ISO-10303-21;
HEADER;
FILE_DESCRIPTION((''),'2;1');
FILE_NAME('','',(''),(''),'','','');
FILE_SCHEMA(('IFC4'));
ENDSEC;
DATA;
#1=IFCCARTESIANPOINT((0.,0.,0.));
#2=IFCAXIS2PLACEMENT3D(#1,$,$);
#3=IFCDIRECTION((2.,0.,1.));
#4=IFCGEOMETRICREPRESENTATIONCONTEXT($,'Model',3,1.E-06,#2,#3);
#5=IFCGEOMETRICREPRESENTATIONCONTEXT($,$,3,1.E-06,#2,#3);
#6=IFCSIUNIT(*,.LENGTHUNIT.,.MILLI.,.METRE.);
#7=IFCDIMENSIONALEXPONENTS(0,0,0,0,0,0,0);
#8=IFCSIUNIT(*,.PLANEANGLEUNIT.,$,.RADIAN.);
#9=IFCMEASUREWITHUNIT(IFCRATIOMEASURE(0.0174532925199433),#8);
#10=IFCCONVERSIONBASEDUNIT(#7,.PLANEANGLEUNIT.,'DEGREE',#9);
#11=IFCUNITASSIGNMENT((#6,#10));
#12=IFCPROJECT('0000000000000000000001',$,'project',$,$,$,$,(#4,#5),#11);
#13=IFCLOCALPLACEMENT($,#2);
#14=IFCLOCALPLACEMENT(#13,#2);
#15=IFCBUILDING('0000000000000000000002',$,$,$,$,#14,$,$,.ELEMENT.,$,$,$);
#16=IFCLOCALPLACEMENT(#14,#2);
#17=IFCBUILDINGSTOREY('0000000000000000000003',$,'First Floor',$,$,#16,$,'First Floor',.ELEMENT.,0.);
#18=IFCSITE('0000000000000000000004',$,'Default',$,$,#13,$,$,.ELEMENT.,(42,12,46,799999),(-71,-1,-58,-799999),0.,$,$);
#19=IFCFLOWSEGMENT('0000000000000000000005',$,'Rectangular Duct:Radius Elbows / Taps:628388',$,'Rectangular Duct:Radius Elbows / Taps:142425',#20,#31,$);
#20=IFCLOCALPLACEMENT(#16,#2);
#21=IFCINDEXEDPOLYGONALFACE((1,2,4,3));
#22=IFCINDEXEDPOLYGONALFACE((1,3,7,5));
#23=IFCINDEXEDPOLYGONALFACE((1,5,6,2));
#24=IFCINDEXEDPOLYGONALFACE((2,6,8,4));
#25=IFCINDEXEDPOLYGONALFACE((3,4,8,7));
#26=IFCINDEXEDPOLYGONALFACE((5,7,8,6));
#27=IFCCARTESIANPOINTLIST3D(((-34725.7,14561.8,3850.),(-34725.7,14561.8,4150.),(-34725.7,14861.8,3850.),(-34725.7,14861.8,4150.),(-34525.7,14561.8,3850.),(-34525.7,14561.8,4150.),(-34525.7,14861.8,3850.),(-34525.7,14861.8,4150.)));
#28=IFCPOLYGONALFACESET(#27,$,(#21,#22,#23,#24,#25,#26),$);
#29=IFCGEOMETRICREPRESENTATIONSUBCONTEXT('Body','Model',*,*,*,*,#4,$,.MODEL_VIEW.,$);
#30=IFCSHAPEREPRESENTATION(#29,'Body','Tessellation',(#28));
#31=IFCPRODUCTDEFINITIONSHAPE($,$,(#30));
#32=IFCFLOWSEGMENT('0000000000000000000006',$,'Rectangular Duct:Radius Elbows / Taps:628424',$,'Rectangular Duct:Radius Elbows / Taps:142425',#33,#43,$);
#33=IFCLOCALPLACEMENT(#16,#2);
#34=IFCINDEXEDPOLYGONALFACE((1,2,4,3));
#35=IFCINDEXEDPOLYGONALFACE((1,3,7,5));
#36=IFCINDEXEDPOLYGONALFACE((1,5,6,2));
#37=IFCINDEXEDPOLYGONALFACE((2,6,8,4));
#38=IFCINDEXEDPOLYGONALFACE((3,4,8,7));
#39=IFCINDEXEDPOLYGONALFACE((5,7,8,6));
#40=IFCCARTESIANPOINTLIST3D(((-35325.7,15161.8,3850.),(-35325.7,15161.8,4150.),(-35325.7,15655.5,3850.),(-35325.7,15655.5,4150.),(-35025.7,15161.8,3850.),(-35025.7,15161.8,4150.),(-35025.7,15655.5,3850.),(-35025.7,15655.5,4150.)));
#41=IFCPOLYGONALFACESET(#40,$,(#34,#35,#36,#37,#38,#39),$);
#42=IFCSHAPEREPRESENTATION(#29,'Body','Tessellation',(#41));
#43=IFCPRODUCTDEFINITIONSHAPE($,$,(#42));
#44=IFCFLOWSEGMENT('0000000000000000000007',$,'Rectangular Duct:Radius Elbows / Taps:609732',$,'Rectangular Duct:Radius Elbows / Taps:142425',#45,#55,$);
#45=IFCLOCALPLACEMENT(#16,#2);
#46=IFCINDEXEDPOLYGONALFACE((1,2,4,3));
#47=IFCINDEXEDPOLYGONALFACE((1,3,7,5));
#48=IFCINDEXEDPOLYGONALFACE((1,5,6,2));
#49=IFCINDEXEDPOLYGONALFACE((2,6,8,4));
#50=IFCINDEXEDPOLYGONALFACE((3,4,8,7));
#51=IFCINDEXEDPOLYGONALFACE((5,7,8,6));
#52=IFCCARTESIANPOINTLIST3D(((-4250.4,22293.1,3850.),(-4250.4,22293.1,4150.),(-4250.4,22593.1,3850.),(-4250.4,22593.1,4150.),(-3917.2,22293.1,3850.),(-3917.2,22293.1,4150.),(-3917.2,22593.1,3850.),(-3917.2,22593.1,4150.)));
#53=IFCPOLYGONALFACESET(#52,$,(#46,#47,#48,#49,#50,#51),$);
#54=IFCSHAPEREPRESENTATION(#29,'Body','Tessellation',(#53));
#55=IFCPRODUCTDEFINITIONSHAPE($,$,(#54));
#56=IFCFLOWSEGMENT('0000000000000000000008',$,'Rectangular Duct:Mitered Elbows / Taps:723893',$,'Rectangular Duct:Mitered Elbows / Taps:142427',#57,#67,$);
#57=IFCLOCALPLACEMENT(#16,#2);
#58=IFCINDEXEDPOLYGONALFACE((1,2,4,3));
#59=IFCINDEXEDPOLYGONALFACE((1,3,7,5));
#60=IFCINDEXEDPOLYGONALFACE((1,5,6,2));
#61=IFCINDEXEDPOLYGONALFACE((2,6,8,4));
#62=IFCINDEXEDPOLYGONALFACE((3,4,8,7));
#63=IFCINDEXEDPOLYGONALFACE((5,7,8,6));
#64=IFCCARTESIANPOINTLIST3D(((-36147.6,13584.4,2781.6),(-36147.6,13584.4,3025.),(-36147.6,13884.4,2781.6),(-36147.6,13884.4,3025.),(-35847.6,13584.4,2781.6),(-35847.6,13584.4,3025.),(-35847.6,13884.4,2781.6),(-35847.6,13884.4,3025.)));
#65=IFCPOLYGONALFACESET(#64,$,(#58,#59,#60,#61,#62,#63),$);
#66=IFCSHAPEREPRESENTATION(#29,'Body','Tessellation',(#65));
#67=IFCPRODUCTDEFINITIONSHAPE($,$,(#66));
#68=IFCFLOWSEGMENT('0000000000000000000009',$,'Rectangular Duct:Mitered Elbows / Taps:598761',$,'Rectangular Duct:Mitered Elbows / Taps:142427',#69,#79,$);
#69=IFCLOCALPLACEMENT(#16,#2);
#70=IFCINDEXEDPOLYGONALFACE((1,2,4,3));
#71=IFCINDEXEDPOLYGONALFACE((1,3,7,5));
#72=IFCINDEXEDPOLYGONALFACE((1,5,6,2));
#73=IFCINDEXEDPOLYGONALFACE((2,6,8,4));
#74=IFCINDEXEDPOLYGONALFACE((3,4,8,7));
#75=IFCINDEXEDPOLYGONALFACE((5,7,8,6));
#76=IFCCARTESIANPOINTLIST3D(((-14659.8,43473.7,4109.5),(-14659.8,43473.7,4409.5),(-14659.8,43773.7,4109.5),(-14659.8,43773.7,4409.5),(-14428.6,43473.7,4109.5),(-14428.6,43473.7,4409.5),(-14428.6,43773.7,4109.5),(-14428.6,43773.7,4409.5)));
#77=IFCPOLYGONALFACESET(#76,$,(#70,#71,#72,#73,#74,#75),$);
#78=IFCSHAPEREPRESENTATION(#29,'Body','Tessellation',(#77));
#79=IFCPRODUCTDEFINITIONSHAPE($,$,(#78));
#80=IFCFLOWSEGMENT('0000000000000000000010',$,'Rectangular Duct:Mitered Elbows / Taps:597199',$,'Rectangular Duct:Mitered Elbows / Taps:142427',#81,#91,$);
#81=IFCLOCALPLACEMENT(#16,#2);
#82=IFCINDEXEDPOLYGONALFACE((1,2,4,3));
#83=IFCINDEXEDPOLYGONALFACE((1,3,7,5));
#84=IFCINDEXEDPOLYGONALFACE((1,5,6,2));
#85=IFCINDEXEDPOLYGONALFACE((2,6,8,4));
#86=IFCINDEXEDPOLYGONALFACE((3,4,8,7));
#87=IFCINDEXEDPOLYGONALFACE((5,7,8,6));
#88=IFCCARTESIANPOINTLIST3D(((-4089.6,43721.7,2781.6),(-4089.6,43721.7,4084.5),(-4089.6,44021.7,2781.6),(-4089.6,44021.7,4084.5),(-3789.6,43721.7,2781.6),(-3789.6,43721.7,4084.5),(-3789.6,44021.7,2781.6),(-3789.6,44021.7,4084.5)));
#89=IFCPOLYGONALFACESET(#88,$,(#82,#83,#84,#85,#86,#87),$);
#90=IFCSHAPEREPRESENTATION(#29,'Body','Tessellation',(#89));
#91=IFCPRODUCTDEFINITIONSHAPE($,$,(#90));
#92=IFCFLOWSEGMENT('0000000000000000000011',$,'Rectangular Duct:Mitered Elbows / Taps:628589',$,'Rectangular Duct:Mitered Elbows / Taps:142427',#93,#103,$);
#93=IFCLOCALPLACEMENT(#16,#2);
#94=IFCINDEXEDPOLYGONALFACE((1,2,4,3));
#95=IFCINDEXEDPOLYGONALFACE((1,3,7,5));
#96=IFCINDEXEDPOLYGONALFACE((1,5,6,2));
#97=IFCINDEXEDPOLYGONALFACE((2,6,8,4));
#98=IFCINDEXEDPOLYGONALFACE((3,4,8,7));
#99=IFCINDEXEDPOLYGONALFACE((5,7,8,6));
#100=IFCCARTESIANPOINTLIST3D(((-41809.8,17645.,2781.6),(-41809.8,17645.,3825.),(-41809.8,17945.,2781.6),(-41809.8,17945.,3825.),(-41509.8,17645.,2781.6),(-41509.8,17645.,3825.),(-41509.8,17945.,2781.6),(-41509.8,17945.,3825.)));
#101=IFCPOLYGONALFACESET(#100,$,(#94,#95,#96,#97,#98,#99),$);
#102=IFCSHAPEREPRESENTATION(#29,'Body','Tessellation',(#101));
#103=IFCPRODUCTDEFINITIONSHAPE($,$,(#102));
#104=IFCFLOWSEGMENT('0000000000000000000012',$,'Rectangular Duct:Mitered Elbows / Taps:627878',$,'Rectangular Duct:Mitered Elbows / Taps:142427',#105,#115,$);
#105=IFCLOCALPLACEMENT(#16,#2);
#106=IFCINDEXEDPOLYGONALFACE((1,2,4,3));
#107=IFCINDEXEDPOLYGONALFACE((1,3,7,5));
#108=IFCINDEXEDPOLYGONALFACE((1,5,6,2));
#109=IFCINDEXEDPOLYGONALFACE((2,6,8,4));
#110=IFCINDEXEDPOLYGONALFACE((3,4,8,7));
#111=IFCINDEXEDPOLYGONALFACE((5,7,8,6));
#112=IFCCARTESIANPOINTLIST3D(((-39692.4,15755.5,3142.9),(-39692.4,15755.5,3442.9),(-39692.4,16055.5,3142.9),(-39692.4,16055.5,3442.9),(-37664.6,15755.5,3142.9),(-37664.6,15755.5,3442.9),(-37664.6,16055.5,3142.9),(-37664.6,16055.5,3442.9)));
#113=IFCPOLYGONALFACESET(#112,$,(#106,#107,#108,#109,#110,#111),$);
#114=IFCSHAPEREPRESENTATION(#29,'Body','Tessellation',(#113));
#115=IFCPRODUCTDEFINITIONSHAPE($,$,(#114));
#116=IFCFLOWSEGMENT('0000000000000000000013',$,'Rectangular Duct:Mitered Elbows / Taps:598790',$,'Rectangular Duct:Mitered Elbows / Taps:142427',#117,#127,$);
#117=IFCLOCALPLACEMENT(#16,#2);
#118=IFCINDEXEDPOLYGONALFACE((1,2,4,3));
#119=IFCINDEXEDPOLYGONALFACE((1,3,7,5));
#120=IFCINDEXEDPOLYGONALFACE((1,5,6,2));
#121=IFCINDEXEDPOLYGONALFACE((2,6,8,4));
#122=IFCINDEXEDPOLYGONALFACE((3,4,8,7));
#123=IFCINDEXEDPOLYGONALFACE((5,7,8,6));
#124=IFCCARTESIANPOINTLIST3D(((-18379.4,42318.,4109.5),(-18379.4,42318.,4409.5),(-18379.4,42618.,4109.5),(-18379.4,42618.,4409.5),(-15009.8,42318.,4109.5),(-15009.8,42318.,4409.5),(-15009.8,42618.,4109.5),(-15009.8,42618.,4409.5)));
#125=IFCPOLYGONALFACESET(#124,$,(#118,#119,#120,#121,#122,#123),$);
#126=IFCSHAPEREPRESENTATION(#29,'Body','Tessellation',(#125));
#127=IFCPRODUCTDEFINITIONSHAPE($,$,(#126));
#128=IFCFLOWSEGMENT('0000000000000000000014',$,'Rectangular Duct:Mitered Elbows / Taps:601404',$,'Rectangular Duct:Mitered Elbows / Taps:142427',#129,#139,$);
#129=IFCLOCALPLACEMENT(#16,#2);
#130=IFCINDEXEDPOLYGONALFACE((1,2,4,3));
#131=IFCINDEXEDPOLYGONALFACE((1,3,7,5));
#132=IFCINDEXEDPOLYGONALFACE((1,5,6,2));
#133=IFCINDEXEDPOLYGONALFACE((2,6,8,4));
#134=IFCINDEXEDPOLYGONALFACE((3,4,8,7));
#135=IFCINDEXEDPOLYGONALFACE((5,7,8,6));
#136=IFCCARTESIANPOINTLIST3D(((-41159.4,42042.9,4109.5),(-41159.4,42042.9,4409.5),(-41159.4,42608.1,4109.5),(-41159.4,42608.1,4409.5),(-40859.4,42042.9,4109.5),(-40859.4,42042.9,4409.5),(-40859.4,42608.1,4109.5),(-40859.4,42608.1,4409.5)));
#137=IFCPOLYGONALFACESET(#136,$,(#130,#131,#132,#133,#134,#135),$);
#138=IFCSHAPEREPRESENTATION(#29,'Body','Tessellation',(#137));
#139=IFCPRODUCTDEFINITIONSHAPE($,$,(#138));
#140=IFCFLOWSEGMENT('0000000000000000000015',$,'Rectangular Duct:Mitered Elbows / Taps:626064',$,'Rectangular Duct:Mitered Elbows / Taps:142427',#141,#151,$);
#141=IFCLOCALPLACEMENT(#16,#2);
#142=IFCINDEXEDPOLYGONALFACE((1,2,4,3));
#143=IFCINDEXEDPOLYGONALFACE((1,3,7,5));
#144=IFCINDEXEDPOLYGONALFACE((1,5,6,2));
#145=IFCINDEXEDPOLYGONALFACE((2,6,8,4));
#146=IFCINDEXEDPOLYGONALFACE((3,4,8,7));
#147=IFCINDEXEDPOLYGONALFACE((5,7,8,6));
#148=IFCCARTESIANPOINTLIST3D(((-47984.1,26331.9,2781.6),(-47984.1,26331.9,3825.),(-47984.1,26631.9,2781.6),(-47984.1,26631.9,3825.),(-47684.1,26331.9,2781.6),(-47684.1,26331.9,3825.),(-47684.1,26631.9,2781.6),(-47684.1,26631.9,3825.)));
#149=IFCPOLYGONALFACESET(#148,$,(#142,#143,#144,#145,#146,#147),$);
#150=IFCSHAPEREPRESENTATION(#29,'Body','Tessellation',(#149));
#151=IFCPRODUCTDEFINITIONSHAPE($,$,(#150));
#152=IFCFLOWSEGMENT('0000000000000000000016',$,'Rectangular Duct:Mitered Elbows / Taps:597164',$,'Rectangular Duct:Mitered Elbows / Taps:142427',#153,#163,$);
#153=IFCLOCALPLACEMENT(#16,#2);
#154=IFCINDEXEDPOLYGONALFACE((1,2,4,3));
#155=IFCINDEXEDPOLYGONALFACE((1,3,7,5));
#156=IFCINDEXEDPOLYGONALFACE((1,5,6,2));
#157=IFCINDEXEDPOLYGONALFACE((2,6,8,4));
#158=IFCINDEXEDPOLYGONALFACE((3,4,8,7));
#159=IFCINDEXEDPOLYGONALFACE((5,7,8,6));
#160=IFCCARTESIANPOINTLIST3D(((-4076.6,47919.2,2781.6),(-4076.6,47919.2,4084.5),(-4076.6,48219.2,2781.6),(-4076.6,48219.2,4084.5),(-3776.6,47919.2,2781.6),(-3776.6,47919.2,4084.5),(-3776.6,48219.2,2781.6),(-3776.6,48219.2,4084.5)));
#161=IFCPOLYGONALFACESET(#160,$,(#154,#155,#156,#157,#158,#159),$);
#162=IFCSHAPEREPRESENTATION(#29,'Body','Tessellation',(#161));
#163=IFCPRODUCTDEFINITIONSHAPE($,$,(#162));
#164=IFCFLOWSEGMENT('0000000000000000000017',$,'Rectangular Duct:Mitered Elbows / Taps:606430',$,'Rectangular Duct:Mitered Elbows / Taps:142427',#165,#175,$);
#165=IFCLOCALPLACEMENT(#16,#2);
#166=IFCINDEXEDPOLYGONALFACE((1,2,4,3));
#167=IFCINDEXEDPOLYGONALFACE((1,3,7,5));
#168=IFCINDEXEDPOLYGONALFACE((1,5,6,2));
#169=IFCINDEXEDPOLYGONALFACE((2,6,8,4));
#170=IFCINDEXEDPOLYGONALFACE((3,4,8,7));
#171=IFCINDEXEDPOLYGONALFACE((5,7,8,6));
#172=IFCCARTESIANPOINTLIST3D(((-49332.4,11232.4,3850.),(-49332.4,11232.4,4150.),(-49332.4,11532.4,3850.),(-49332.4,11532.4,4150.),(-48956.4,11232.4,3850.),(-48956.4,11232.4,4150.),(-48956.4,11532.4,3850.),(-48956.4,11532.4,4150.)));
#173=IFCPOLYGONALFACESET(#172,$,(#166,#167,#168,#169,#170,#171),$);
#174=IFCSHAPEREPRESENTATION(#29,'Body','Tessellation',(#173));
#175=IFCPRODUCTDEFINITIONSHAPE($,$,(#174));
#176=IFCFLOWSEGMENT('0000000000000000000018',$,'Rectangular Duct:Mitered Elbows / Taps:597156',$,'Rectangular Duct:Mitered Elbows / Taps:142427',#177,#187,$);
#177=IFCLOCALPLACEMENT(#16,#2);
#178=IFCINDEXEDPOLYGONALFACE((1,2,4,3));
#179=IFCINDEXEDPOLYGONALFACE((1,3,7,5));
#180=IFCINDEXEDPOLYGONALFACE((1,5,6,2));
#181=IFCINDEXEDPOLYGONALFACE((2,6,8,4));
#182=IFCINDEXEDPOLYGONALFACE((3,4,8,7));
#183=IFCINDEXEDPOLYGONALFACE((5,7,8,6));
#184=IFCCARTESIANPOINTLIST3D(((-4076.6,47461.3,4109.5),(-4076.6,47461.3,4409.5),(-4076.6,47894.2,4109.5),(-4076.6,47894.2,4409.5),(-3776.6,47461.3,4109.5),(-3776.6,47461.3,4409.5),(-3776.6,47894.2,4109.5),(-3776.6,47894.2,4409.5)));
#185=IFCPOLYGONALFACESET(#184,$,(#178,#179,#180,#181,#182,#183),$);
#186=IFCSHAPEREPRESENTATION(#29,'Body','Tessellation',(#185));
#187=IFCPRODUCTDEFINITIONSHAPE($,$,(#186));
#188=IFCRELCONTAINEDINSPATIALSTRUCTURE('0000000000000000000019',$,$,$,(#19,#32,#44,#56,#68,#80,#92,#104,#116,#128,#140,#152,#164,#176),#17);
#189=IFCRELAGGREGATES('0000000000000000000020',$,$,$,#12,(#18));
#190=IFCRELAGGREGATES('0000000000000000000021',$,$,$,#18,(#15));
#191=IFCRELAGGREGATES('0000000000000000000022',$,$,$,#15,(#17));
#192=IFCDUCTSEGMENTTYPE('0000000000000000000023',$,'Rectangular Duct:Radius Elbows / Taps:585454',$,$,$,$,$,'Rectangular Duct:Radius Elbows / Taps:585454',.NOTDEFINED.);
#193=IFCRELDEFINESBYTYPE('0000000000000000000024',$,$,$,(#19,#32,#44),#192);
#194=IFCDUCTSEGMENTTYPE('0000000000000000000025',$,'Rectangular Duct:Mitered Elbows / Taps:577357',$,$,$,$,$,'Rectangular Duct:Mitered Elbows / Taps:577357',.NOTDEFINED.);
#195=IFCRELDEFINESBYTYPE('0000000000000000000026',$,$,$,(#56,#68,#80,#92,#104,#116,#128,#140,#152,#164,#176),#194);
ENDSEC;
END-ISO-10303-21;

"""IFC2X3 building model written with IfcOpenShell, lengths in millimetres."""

from ifc_helpers import new_model, entity, si_unit, converted_unit, direction, frame, frame_2d, origin, origin_2d_with_axis, place, context, subcontext, project, spatial, rectangle, extrude, type_object, element, save


model = new_model("IFC2X3")

# Units and contexts
model_context = context("Model", 3, precision=1e-06, world=origin(), true_north=direction((2.0, 0.0, 1.0)))
context_of_model = context(None, 3, precision=1e-06, world=origin(), true_north=direction((2.0, 0.0, 1.0)))
body_context = subcontext(model_context, "Body", "Model", "MODEL_VIEW")
ifc_project = project(units=[si_unit("LENGTHUNIT", "METRE", prefix="MILLI"), converted_unit("PLANEANGLEUNIT", "DEGREE", entity("IfcRatioMeasure", 0.0174532925199433), si_unit("PLANEANGLEUNIT", "RADIAN"), dimensions=[0, 0, 0, 0, 0, 0, 0])], contexts=[model_context, context_of_model])

# Site, building, storey
site_placement = place(None, origin())
site = spatial("IfcSite", under=ifc_project, at=site_placement, Name="Default", CompositionType="ELEMENT", RefLatitude=(42, 12, 46, 799999), RefLongitude=(-71, -1, -58, -799999), RefElevation=0.0)
building_placement = place(site_placement, origin())
building = spatial("IfcBuilding", under=site, at=building_placement, CompositionType="ELEMENT")
storey_placement = place(building_placement, origin())
storey = spatial("IfcBuildingStorey", under=building, at=storey_placement, Name="First Floor", LongName="First Floor", CompositionType="ELEMENT", Elevation=0.0)

# Flow segments
duct_segment_type_1 = type_object("IfcDuctSegmentType", Name="Rectangular Duct:Radius Elbows / Taps:585454", ElementType="Rectangular Duct:Radius Elbows / Taps:585454", PredefinedType="NOTDEFINED")
flow_segment_1_placement = place(storey_placement, origin())
element("IfcFlowSegment", 1, at=flow_segment_1_placement, inside=storey, type_object=duct_segment_type_1, Name="Rectangular Duct:Radius Elbows / Taps:628388", ObjectType="Rectangular Duct:Radius Elbows / Taps:142425", context=body_context, shape_type="SweptSolid", body=[
    extrude(rectangle(XDim=200.0, YDim=300.0, at=origin_2d_with_axis()), frame((-34625.7, 14711.8, 3850.0), z_axis=(0.0, 0.0, 1.0), x_axis=(-1.0, 0.0, 0.0)), (0.0, 0.0, 1.0), 300.0),
])
flow_segment_2_placement = place(storey_placement, origin())
element("IfcFlowSegment", 2, at=flow_segment_2_placement, inside=storey, type_object=duct_segment_type_1, Name="Rectangular Duct:Radius Elbows / Taps:628424", ObjectType="Rectangular Duct:Radius Elbows / Taps:142425", context=body_context, shape_type="SweptSolid", body=[
    extrude(rectangle(XDim=493.7, YDim=300.0, at=frame_2d((0.0, 0.0), x_axis=(1.0, 0.0))), frame((-35175.7, 15408.6, 3850.0), z_axis=(0.0, 0.0, 1.0), x_axis=(0.0, -1.0, 0.0)), (0.0, 0.0, 1.0), 300.0),
])
flow_segment_3_placement = place(storey_placement, origin())
element("IfcFlowSegment", 3, at=flow_segment_3_placement, inside=storey, type_object=duct_segment_type_1, Name="Rectangular Duct:Radius Elbows / Taps:609732", ObjectType="Rectangular Duct:Radius Elbows / Taps:142425", context=body_context, shape_type="SweptSolid", body=[
    extrude(rectangle(XDim=333.2, YDim=300.0, at=frame_2d((0.0, 0.0), x_axis=(1.0, 0.0))), frame((-4083.8, 22443.1, 3850.0), z_axis=(0.0, 0.0, 1.0), x_axis=(-1.0, 0.0, 0.0)), (0.0, 0.0, 1.0), 300.0),
])
duct_segment_type_2 = type_object("IfcDuctSegmentType", Name="Rectangular Duct:Mitered Elbows / Taps:577357", ElementType="Rectangular Duct:Mitered Elbows / Taps:577357", PredefinedType="NOTDEFINED")
flow_segment_4_placement = place(storey_placement, origin())
element("IfcFlowSegment", 4, at=flow_segment_4_placement, inside=storey, type_object=duct_segment_type_2, Name="Rectangular Duct:Mitered Elbows / Taps:723893", ObjectType="Rectangular Duct:Mitered Elbows / Taps:142427", context=body_context, shape_type="SweptSolid", body=[
    extrude(rectangle(XDim=300.0, YDim=300.0, at=origin_2d_with_axis()), frame((-35997.6, 13734.4, 2781.6), z_axis=(0.0, 0.0, 1.0), x_axis=(0.0, -1.0, 0.0)), (0.0, 0.0, 1.0), 243.4),
])
flow_segment_5_placement = place(storey_placement, origin())
element("IfcFlowSegment", 5, at=flow_segment_5_placement, inside=storey, type_object=duct_segment_type_2, Name="Rectangular Duct:Mitered Elbows / Taps:598761", ObjectType="Rectangular Duct:Mitered Elbows / Taps:142427", context=body_context, shape_type="SweptSolid", body=[
    extrude(rectangle(XDim=231.2, YDim=300.0, at=frame_2d((0.0, 0.0), x_axis=(1.0, 0.0))), frame((-14544.2, 43623.7, 4109.5), z_axis=(0.0, 0.0, 1.0), x_axis=(-1.0, 0.0, 0.0)), (0.0, 0.0, 1.0), 300.0),
])
flow_segment_6_placement = place(storey_placement, origin())
element("IfcFlowSegment", 6, at=flow_segment_6_placement, inside=storey, type_object=duct_segment_type_2, Name="Rectangular Duct:Mitered Elbows / Taps:597199", ObjectType="Rectangular Duct:Mitered Elbows / Taps:142427", context=body_context, shape_type="SweptSolid", body=[
    extrude(rectangle(XDim=300.0, YDim=300.0, at=origin_2d_with_axis()), frame((-3939.6, 43871.7, 2781.6), z_axis=(0.0, 0.0, 1.0), x_axis=(0.0, -1.0, 0.0)), (0.0, 0.0, 1.0), 1302.9),
])
flow_segment_7_placement = place(storey_placement, origin())
element("IfcFlowSegment", 7, at=flow_segment_7_placement, inside=storey, type_object=duct_segment_type_2, Name="Rectangular Duct:Mitered Elbows / Taps:628589", ObjectType="Rectangular Duct:Mitered Elbows / Taps:142427", context=body_context, shape_type="SweptSolid", body=[
    extrude(rectangle(XDim=300.0, YDim=300.0, at=origin_2d_with_axis()), frame((-41659.8, 17795.0, 2781.6), z_axis=(0.0, 0.0, 1.0), x_axis=(0.0, -1.0, 0.0)), (0.0, 0.0, 1.0), 1043.4),
])
flow_segment_8_placement = place(storey_placement, origin())
element("IfcFlowSegment", 8, at=flow_segment_8_placement, inside=storey, type_object=duct_segment_type_2, Name="Rectangular Duct:Mitered Elbows / Taps:627878", ObjectType="Rectangular Duct:Mitered Elbows / Taps:142427", context=body_context, shape_type="SweptSolid", body=[
    extrude(rectangle(XDim=2027.8, YDim=300.0, at=frame_2d((0.0, 0.0), x_axis=(1.0, 0.0))), frame((-38678.5, 15905.5, 3142.9), z_axis=(0.0, 0.0, 1.0), x_axis=(-1.0, 0.0, 0.0)), (0.0, 0.0, 1.0), 300.0),
])
flow_segment_9_placement = place(storey_placement, origin())
element("IfcFlowSegment", 9, at=flow_segment_9_placement, inside=storey, type_object=duct_segment_type_2, Name="Rectangular Duct:Mitered Elbows / Taps:598790", ObjectType="Rectangular Duct:Mitered Elbows / Taps:142427", context=body_context, shape_type="SweptSolid", body=[
    extrude(rectangle(XDim=3369.6, YDim=300.0, at=frame_2d((0.0, 0.0), x_axis=(1.0, 0.0))), frame((-16694.6, 42468.0, 4109.5)), (0.0, 0.0, 1.0), 300.0),
])
flow_segment_10_placement = place(storey_placement, origin())
element("IfcFlowSegment", 10, at=flow_segment_10_placement, inside=storey, type_object=duct_segment_type_2, Name="Rectangular Duct:Mitered Elbows / Taps:601404", ObjectType="Rectangular Duct:Mitered Elbows / Taps:142427", context=body_context, shape_type="SweptSolid", body=[
    extrude(rectangle(XDim=565.2, YDim=300.0, at=frame_2d((0.0, 0.0), x_axis=(1.0, 0.0))), frame((-41009.4, 42325.5, 4109.5), z_axis=(0.0, 0.0, 1.0), x_axis=(0.0, -1.0, 0.0)), (0.0, 0.0, 1.0), 300.0),
])
flow_segment_11_placement = place(storey_placement, origin())
element("IfcFlowSegment", 11, at=flow_segment_11_placement, inside=storey, type_object=duct_segment_type_2, Name="Rectangular Duct:Mitered Elbows / Taps:626064", ObjectType="Rectangular Duct:Mitered Elbows / Taps:142427", context=body_context, shape_type="SweptSolid", body=[
    extrude(rectangle(XDim=300.0, YDim=300.0, at=origin_2d_with_axis()), frame((-47834.1, 26481.9, 2781.6), z_axis=(0.0, 0.0, 1.0), x_axis=(0.0, 1.0, 0.0)), (0.0, 0.0, 1.0), 1043.4),
])
flow_segment_12_placement = place(storey_placement, origin())
element("IfcFlowSegment", 12, at=flow_segment_12_placement, inside=storey, type_object=duct_segment_type_2, Name="Rectangular Duct:Mitered Elbows / Taps:597164", ObjectType="Rectangular Duct:Mitered Elbows / Taps:142427", context=body_context, shape_type="SweptSolid", body=[
    extrude(rectangle(XDim=300.0, YDim=300.0, at=origin_2d_with_axis()), frame((-3926.6, 48069.2, 2781.6), z_axis=(0.0, 0.0, 1.0), x_axis=(0.0, 1.0, 0.0)), (0.0, 0.0, 1.0), 1302.9),
])
flow_segment_13_placement = place(storey_placement, origin())
element("IfcFlowSegment", 13, at=flow_segment_13_placement, inside=storey, type_object=duct_segment_type_2, Name="Rectangular Duct:Mitered Elbows / Taps:606430", ObjectType="Rectangular Duct:Mitered Elbows / Taps:142427", context=body_context, shape_type="SweptSolid", body=[
    extrude(rectangle(XDim=376.0, YDim=300.0, at=frame_2d((0.0, 0.0), x_axis=(1.0, 0.0))), frame((-49144.4, 11382.4, 3850.0)), (0.0, 0.0, 1.0), 300.0),
])
flow_segment_14_placement = place(storey_placement, origin())
element("IfcFlowSegment", 14, at=flow_segment_14_placement, inside=storey, type_object=duct_segment_type_2, Name="Rectangular Duct:Mitered Elbows / Taps:597156", ObjectType="Rectangular Duct:Mitered Elbows / Taps:142427", context=body_context, shape_type="SweptSolid", body=[
    extrude(rectangle(XDim=432.9, YDim=300.0, at=frame_2d((0.0, 0.0), x_axis=(1.0, 0.0))), frame((-3926.6, 47677.8, 4109.5), z_axis=(0.0, 0.0, 1.0), x_axis=(0.0, -1.0, 0.0)), (0.0, 0.0, 1.0), 300.0),
])

save(model, "model.ifc")
